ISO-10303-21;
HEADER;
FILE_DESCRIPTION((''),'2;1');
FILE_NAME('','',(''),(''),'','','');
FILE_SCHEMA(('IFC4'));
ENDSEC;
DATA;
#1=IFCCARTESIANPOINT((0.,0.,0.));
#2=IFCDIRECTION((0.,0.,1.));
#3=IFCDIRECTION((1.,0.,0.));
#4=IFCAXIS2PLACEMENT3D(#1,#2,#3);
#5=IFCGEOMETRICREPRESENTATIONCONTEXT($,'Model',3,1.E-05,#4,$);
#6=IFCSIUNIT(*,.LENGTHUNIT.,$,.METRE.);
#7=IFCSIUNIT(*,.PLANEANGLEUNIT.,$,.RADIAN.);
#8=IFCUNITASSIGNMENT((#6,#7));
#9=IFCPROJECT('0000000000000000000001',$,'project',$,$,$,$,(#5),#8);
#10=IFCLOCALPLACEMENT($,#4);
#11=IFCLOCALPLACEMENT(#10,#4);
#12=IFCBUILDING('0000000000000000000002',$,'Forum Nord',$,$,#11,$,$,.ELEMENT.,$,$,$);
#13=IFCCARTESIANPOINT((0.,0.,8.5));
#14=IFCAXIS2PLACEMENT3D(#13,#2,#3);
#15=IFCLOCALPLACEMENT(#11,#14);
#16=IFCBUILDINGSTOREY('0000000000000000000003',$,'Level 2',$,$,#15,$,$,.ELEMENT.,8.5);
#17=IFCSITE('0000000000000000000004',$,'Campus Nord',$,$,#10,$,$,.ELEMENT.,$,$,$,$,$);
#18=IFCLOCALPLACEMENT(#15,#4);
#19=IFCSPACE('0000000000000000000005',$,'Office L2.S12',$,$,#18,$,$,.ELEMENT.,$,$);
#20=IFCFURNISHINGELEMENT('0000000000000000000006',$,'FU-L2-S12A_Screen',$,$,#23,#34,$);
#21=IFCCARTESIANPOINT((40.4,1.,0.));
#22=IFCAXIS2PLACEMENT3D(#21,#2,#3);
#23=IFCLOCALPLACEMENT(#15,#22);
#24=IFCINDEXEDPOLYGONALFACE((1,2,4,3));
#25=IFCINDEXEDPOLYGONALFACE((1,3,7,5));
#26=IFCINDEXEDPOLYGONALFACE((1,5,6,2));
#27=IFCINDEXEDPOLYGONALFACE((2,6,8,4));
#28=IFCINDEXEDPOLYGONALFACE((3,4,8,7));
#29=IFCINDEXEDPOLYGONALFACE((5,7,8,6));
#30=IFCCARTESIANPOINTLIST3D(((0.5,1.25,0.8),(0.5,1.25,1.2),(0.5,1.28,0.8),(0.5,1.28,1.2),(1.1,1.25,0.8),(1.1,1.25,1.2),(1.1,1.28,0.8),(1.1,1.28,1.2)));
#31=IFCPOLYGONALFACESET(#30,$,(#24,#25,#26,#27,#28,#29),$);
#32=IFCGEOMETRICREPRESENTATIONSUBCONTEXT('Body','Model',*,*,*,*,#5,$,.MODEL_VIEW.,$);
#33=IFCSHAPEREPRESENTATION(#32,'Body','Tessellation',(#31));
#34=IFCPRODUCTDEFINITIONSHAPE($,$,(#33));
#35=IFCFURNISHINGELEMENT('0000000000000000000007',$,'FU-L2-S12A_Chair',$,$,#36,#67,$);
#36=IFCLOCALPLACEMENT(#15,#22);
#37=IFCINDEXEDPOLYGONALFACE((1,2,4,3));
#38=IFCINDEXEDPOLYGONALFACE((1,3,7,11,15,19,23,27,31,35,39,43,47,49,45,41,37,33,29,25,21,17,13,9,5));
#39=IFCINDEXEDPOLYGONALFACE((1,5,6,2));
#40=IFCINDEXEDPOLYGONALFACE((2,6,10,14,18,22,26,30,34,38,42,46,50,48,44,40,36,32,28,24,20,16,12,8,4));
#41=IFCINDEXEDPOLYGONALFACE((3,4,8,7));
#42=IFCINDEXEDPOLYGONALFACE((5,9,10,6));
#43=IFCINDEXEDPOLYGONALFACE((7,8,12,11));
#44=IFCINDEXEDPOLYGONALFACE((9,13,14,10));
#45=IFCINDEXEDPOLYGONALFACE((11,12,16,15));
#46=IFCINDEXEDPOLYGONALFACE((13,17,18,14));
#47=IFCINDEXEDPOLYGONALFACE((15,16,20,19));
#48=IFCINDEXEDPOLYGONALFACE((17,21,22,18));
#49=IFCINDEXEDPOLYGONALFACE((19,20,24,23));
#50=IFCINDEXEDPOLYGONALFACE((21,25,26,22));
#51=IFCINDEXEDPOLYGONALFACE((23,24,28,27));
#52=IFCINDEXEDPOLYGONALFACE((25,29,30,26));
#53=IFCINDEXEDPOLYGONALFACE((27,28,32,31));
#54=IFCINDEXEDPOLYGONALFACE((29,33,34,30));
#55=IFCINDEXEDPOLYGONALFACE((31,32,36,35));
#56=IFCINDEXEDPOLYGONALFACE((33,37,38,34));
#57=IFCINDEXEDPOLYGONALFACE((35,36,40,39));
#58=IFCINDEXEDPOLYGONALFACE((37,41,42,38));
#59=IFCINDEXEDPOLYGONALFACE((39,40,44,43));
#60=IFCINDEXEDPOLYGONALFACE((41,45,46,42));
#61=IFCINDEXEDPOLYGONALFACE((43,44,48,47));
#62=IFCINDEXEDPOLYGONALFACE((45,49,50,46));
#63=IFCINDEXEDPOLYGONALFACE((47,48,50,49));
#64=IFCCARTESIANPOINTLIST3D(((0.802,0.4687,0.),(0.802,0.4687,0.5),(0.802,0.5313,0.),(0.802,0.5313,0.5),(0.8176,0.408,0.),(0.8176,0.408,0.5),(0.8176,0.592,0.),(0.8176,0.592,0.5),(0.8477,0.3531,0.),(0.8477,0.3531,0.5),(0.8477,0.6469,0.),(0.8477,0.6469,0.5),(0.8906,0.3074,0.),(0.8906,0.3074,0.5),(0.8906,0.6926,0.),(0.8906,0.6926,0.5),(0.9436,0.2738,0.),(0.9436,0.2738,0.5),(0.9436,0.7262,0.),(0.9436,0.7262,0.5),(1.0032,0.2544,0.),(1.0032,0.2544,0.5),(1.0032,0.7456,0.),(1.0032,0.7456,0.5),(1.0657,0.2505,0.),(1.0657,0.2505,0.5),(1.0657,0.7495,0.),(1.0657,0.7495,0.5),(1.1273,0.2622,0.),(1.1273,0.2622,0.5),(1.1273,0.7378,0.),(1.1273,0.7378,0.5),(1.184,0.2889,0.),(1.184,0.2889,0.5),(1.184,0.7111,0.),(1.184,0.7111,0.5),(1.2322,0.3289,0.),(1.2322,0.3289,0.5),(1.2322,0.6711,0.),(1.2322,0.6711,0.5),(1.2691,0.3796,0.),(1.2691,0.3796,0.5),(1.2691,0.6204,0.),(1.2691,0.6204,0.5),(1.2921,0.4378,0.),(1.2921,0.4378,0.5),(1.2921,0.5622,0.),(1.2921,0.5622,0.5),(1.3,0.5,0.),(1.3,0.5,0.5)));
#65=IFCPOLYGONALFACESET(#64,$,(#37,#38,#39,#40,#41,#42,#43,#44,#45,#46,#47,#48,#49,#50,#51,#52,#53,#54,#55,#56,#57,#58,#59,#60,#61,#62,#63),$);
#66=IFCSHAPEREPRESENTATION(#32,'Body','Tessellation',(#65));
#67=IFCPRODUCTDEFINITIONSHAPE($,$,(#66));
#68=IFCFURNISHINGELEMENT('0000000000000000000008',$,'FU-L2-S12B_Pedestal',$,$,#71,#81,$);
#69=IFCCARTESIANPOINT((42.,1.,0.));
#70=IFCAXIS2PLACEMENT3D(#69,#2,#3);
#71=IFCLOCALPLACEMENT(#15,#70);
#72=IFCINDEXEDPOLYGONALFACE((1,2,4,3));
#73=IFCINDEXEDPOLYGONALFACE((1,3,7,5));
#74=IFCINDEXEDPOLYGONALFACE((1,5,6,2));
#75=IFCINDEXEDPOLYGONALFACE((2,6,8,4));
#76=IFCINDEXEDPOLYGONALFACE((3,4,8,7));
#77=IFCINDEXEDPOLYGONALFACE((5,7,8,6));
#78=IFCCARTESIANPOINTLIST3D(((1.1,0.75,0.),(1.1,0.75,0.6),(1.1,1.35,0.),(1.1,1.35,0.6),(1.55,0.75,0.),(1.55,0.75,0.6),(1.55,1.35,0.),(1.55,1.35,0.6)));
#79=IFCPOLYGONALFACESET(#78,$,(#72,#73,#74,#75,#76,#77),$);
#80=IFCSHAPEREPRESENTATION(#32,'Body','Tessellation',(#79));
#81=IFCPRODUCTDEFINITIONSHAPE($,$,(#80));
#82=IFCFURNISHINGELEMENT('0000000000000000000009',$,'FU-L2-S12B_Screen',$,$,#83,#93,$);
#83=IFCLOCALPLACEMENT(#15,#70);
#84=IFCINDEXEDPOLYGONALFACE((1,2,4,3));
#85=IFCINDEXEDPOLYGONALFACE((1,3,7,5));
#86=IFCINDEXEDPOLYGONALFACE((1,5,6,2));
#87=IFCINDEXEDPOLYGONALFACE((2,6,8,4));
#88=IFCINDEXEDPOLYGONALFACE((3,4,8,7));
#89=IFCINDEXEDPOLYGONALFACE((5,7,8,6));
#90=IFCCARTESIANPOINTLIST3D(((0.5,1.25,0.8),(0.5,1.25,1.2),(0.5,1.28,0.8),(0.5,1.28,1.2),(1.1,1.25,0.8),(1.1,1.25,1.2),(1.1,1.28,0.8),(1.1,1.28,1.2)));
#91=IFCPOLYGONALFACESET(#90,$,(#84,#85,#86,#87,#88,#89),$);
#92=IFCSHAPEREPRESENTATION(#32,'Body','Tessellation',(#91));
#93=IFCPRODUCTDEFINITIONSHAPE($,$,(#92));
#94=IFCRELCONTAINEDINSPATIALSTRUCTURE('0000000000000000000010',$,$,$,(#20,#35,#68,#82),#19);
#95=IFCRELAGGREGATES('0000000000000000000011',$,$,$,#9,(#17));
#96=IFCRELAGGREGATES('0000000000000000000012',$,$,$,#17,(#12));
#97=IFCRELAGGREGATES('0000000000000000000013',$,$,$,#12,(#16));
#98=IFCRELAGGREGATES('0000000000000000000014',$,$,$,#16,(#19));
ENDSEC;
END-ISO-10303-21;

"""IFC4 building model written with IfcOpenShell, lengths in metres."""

from ifc_helpers import new_model, si_unit, frame, frame_2d, origin_with_axes, place, context, subcontext, project, spatial, rectangle, circle, extrude, element, save


model = new_model("IFC4")

# Units and contexts
model_context = context("Model", 3, precision=1e-05, world=origin_with_axes())
body_context = subcontext(model_context, "Body", "Model", "MODEL_VIEW")
ifc_project = project(units=[si_unit("LENGTHUNIT", "METRE"), si_unit("PLANEANGLEUNIT", "RADIAN")], contexts=[model_context])

# Site, building, storey
site_placement = place(None, origin_with_axes())
site = spatial("IfcSite", under=ifc_project, at=site_placement, Name="Campus Nord", CompositionType="ELEMENT")
building_placement = place(site_placement, origin_with_axes())
building = spatial("IfcBuilding", under=site, at=building_placement, Name="Forum Nord", CompositionType="ELEMENT")
storey_placement = place(building_placement, frame((0.0, 0.0, 8.5), z_axis=(0.0, 0.0, 1.0), x_axis=(1.0, 0.0, 0.0)))
storey = spatial("IfcBuildingStorey", under=building, at=storey_placement, Name="Level 2", CompositionType="ELEMENT", Elevation=8.5)

# Shared definitions
space_1_placement = place(storey_placement, origin_with_axes())
space_1 = spatial("IfcSpace", under=storey, at=space_1_placement, Name="Office L2.S12", CompositionType="ELEMENT")

# Furnishing elements
furnishing_1_placement = place(storey_placement, frame((40.4, 1.0, 0.0), z_axis=(0.0, 0.0, 1.0), x_axis=(1.0, 0.0, 0.0)))
element("IfcFurnishingElement", 1, at=furnishing_1_placement, inside=space_1, Name="FU-L2-S12A_Screen", context=body_context, shape_type="SweptSolid", body=[
    extrude(rectangle(XDim=0.6, YDim=0.03, at=frame_2d((0.8, 1.265), x_axis=(1.0, 0.0))), frame((0.0, 0.0, 0.8), z_axis=(0.0, 0.0, 1.0), x_axis=(1.0, 0.0, 0.0)), (0.0, 0.0, 1.0), 0.4),
])
furnishing_2_placement = place(storey_placement, frame((40.4, 1.0, 0.0), z_axis=(0.0, 0.0, 1.0), x_axis=(1.0, 0.0, 0.0)))
element("IfcFurnishingElement", 2, at=furnishing_2_placement, inside=space_1, Name="FU-L2-S12A_Chair", context=body_context, shape_type="SweptSolid", body=[
    extrude(circle(Radius=0.25, at=frame_2d((1.05, 0.5), x_axis=(1.0, 0.0))), origin_with_axes(), (0.0, 0.0, 1.0), 0.5),
])
furnishing_3_placement = place(storey_placement, frame((42.0, 1.0, 0.0), z_axis=(0.0, 0.0, 1.0), x_axis=(1.0, 0.0, 0.0)))
element("IfcFurnishingElement", 3, at=furnishing_3_placement, inside=space_1, Name="FU-L2-S12B_Pedestal", context=body_context, shape_type="SweptSolid", body=[
    extrude(rectangle(XDim=0.45, YDim=0.6, at=frame_2d((1.325, 1.05), x_axis=(1.0, 0.0))), origin_with_axes(), (0.0, 0.0, 1.0), 0.6),
])
furnishing_4_placement = place(storey_placement, frame((42.0, 1.0, 0.0), z_axis=(0.0, 0.0, 1.0), x_axis=(1.0, 0.0, 0.0)))
element("IfcFurnishingElement", 4, at=furnishing_4_placement, inside=space_1, Name="FU-L2-S12B_Screen", context=body_context, shape_type="SweptSolid", body=[
    extrude(rectangle(XDim=0.6, YDim=0.03, at=frame_2d((0.8, 1.265), x_axis=(1.0, 0.0))), frame((0.0, 0.0, 0.8), z_axis=(0.0, 0.0, 1.0), x_axis=(1.0, 0.0, 0.0)), (0.0, 0.0, 1.0), 0.4),
])

save(model, "model.ifc")
